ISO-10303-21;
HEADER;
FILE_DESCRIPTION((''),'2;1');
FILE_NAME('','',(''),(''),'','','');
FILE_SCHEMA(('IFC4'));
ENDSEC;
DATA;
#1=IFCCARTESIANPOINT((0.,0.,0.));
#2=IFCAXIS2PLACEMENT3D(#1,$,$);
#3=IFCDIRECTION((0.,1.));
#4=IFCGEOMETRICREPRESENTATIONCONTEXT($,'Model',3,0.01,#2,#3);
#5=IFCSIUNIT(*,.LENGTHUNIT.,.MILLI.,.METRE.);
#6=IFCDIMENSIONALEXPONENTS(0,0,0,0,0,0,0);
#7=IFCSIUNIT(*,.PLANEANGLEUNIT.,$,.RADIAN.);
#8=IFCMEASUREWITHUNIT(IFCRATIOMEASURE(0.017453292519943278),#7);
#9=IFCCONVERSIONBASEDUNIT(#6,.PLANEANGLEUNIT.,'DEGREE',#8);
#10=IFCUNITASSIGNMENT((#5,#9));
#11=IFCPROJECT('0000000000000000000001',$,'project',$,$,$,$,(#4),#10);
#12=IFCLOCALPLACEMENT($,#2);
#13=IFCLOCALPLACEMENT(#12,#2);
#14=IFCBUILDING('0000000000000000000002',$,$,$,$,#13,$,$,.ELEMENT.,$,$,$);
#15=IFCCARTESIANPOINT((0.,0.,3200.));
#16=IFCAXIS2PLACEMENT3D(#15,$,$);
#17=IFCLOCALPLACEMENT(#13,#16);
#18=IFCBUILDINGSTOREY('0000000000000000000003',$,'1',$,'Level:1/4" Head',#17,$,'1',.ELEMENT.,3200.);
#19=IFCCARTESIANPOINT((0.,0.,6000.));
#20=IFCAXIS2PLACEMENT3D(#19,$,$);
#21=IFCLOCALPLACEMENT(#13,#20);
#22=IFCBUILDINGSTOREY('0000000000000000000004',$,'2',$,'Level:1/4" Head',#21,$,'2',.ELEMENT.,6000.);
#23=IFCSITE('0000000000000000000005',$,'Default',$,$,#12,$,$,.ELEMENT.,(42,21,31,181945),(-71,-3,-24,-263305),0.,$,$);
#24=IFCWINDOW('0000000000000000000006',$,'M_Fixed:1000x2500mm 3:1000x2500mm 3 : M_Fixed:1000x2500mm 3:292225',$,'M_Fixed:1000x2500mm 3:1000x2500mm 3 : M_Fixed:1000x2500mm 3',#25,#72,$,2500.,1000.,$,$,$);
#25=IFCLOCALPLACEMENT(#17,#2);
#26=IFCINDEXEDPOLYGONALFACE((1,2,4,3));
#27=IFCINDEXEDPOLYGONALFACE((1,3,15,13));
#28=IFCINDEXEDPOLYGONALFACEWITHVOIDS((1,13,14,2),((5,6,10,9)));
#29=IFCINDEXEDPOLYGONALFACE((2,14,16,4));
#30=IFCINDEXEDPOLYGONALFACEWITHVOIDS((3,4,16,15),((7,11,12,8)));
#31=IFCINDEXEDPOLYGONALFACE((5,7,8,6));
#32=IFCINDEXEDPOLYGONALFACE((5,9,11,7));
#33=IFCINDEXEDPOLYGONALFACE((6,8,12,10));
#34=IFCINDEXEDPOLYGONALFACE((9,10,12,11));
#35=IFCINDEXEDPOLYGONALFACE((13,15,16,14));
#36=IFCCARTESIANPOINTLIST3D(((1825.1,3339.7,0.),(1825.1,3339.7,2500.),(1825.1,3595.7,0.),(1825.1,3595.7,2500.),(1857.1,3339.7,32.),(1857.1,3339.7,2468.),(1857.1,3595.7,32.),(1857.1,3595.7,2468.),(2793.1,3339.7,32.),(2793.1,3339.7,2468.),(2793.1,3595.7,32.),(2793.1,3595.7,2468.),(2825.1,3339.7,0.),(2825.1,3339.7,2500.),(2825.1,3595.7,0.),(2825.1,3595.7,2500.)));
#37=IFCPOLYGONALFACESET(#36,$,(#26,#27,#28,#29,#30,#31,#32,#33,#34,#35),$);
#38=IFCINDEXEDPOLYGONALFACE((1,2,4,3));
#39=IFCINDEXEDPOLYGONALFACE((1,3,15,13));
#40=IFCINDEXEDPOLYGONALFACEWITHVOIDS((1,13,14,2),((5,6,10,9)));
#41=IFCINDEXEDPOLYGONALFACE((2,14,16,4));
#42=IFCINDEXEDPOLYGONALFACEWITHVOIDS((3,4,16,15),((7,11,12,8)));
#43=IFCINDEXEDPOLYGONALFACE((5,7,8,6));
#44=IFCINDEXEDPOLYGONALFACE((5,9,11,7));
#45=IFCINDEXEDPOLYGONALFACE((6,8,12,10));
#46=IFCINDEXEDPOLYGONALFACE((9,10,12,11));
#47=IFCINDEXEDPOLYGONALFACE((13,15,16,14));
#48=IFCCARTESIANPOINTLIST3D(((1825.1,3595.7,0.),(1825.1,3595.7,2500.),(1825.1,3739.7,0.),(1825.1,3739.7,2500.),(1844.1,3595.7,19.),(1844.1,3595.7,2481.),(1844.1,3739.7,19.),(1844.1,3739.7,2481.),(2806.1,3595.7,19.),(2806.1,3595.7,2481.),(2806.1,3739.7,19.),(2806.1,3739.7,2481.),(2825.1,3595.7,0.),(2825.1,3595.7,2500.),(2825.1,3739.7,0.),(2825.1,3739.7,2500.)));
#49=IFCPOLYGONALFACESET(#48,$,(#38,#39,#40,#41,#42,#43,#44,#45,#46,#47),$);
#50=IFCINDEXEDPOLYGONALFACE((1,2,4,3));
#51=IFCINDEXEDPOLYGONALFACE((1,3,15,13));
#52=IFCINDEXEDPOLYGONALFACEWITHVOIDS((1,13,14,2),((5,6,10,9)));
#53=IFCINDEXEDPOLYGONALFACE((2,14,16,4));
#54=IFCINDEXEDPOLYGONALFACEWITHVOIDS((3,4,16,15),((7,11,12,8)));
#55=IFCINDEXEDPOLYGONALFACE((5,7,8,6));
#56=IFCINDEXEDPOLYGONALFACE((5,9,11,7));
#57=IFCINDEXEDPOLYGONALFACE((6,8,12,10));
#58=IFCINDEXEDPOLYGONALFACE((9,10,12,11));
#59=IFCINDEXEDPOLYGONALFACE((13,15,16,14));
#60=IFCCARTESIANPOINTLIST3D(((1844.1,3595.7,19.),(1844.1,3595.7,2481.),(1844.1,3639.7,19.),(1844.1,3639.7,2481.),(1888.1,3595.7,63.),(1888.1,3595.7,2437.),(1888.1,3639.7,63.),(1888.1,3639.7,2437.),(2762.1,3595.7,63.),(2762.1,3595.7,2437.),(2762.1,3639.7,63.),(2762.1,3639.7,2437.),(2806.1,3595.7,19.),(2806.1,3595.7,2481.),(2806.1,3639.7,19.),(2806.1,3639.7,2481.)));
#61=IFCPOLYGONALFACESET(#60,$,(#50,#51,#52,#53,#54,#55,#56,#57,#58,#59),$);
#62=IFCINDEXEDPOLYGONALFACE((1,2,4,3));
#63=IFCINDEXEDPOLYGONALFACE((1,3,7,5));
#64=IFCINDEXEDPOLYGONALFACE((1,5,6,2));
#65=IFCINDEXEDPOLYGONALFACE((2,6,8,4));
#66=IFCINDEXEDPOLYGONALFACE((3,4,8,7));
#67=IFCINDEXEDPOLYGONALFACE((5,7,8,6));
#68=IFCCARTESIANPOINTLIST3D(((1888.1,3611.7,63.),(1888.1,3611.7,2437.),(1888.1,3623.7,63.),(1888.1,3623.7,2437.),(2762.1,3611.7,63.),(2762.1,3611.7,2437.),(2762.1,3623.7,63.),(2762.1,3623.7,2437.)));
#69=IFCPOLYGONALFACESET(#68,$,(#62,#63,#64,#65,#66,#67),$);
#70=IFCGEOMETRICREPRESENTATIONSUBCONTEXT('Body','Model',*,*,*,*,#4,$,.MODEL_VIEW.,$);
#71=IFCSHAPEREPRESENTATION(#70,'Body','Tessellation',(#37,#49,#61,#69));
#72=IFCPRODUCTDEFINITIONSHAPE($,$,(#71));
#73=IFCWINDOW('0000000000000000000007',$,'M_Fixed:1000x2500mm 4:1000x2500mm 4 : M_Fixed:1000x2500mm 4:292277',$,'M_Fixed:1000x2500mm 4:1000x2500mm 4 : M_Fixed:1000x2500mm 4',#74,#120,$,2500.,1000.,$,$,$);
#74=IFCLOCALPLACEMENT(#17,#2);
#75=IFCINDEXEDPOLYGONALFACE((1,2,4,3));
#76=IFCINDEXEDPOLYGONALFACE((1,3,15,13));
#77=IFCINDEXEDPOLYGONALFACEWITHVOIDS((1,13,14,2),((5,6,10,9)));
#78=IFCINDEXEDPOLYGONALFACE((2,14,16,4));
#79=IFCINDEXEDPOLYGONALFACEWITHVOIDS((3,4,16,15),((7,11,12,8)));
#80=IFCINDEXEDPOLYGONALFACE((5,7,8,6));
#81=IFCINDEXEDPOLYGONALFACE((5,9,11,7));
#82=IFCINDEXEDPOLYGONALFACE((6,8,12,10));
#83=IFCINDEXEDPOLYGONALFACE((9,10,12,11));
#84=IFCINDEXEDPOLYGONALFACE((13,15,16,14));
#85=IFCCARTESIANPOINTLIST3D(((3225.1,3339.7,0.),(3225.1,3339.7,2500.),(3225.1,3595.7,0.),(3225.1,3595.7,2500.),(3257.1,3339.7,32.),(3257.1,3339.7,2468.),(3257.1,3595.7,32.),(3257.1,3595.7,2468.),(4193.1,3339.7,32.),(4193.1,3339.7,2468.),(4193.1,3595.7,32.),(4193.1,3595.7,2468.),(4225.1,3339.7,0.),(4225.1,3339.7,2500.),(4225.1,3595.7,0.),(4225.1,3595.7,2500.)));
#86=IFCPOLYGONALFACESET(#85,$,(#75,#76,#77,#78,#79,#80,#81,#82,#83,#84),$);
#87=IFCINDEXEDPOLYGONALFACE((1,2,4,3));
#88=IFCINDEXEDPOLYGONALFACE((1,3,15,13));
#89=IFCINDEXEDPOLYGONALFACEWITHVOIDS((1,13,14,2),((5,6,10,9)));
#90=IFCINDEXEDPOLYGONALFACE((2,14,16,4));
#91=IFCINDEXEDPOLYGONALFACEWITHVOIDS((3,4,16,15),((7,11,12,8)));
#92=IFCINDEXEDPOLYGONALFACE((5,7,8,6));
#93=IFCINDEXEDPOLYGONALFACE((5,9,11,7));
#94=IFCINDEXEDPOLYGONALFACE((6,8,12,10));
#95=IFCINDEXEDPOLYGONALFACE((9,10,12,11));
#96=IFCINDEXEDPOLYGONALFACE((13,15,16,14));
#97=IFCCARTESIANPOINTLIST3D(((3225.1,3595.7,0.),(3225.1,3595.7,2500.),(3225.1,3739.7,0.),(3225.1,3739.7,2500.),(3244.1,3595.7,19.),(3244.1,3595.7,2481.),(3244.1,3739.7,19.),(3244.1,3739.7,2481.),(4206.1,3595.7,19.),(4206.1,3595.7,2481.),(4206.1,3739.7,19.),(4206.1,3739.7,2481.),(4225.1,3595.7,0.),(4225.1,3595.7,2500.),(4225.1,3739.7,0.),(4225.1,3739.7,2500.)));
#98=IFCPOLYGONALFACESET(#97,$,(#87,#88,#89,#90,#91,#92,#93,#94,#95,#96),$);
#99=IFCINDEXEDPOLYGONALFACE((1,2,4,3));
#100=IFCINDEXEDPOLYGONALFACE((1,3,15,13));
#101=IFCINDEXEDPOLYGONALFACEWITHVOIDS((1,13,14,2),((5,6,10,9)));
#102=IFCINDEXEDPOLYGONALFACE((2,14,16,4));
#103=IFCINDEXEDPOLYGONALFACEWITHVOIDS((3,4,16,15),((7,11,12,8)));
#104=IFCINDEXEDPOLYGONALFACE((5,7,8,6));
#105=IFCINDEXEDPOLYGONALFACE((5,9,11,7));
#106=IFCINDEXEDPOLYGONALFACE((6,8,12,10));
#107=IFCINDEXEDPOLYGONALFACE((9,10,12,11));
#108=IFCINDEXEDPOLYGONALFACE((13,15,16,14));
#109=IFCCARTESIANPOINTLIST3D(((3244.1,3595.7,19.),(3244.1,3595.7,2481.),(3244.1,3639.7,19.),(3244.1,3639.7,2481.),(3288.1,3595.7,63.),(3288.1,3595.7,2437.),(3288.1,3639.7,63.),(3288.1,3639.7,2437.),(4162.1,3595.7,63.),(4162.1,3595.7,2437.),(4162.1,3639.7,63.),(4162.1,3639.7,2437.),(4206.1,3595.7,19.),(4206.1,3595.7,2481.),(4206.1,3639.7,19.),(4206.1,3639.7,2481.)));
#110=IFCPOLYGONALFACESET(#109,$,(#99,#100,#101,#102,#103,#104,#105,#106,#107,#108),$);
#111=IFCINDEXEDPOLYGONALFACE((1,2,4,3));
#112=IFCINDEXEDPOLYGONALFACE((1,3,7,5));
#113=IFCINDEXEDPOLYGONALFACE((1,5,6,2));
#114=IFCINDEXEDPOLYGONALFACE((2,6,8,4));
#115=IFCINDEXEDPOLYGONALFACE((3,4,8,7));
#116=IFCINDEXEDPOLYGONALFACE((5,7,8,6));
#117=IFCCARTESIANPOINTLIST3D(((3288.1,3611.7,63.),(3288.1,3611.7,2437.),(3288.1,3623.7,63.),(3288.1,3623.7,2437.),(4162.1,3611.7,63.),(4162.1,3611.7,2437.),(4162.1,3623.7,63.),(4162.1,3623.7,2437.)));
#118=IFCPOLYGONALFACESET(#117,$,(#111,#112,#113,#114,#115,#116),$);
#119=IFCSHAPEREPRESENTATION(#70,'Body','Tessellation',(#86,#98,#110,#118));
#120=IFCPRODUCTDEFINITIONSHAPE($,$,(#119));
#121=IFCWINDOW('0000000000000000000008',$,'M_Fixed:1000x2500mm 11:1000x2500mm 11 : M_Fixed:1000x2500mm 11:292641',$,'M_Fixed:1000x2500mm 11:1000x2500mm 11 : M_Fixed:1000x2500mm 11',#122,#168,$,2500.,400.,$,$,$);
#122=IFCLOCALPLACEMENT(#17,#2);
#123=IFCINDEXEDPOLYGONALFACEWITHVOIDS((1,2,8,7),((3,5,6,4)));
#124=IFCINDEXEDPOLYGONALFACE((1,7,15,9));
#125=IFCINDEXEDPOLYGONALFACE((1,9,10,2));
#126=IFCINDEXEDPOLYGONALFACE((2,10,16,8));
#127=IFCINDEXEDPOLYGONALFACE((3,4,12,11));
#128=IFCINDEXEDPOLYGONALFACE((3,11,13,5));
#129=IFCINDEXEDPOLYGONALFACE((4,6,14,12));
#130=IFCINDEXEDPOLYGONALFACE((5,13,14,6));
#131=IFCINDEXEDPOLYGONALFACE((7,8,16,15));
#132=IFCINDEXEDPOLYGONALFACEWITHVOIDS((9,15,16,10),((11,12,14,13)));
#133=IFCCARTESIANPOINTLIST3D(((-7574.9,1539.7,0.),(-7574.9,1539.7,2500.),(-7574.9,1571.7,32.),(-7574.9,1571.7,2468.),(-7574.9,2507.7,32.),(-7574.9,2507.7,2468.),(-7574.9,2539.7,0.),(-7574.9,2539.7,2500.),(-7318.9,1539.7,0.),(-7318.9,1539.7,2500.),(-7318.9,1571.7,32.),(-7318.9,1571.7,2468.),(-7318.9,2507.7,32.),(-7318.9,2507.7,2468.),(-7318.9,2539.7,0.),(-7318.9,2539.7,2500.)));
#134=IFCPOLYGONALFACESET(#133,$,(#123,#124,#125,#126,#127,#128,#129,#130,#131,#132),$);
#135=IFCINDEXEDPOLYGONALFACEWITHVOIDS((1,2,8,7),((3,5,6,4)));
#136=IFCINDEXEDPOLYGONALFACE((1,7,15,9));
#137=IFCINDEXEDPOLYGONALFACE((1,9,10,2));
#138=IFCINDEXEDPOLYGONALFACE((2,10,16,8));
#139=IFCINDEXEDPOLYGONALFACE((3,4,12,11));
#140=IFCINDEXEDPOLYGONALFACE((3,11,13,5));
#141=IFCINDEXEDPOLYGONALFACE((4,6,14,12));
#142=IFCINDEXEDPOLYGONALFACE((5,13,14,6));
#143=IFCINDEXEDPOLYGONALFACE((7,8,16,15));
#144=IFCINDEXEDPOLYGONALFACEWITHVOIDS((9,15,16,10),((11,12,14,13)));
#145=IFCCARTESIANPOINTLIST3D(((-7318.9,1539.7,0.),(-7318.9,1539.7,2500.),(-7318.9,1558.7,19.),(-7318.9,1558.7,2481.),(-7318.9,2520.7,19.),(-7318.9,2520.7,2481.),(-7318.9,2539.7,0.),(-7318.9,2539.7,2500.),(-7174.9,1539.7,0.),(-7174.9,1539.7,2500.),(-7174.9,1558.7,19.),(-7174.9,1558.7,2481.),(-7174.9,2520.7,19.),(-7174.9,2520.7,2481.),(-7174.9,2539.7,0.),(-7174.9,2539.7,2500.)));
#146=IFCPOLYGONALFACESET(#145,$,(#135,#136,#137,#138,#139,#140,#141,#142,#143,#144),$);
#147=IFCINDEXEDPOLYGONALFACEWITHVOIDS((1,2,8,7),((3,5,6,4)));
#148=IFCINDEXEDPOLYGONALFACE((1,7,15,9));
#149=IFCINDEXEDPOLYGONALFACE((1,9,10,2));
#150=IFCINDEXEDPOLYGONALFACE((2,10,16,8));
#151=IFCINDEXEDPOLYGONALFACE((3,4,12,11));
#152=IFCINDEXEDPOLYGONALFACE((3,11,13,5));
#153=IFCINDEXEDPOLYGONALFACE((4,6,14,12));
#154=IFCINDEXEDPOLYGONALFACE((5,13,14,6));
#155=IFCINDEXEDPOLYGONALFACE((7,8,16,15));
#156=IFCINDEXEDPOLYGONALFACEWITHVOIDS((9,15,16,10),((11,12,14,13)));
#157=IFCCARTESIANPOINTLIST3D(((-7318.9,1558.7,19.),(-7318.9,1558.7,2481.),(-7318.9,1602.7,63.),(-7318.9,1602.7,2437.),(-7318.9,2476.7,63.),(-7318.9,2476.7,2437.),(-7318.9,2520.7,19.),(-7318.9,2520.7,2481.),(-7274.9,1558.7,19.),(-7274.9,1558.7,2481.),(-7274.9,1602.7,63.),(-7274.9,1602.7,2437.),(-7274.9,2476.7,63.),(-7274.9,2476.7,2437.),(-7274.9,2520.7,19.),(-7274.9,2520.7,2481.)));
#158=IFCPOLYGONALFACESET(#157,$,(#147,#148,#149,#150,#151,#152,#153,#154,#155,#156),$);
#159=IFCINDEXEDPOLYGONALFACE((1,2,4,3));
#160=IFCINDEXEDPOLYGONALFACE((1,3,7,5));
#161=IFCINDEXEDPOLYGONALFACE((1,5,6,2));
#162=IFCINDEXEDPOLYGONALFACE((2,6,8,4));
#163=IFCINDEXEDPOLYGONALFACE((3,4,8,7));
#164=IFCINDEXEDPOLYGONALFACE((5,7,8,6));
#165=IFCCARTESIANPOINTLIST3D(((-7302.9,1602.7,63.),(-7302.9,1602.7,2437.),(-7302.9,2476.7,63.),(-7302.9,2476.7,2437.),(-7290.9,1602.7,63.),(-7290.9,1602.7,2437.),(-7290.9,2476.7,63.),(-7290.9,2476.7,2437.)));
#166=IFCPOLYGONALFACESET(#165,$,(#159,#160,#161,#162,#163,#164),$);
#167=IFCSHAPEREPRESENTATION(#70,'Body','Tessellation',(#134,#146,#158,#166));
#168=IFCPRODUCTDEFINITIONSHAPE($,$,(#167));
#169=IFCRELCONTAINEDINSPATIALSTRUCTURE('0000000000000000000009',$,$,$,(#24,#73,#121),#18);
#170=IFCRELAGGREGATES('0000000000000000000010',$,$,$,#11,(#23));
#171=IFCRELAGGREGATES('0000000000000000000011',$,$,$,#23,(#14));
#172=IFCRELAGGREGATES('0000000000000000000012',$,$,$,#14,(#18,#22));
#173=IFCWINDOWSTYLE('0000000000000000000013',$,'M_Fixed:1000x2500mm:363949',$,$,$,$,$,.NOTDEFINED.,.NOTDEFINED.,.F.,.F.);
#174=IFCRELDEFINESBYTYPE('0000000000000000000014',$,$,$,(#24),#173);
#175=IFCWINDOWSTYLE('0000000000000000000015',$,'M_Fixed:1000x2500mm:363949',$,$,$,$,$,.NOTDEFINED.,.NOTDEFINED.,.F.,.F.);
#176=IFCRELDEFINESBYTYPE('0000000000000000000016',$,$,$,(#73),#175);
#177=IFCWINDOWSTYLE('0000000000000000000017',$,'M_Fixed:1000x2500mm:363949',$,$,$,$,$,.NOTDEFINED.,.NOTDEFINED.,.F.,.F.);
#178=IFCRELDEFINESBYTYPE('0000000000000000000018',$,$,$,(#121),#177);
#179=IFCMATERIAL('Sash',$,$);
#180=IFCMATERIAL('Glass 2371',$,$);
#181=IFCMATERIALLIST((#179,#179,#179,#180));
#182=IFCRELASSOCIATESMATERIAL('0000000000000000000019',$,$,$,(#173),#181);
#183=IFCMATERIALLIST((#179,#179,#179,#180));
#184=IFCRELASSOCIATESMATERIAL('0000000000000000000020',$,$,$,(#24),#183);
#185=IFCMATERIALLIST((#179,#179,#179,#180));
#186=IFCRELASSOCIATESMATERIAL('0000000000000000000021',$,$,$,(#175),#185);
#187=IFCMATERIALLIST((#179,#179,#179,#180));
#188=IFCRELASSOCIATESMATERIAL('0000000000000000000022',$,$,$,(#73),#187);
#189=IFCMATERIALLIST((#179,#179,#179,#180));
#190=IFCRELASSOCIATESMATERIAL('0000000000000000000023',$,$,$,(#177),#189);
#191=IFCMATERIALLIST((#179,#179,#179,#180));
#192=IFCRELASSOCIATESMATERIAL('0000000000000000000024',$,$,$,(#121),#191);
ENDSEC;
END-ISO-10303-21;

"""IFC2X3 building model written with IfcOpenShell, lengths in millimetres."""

from ifc_helpers import new_model, entity, si_unit, converted_unit, direction, frame, frame_2d, origin, origin_2d_with_axis, place, context, subcontext, project, spatial, polyline, rectangle, outline, extrude, source, transform, mapped, material, material_list, type_object, type_shapes, element, save


model = new_model("IFC2X3")

# Units and contexts
model_context = context("Model", 3, precision=0.01, world=origin(), true_north=direction((0.0, 1.0)))
body_context = subcontext(model_context, "Body", "Model", "MODEL_VIEW")
ifc_project = project(units=[si_unit("LENGTHUNIT", "METRE", prefix="MILLI"), converted_unit("PLANEANGLEUNIT", "DEGREE", entity("IfcRatioMeasure", 0.017453292519943278), si_unit("PLANEANGLEUNIT", "RADIAN"), dimensions=[0, 0, 0, 0, 0, 0, 0])], contexts=[model_context])

# Site, building, storey
site_placement = place(None, origin())
site = spatial("IfcSite", under=ifc_project, at=site_placement, Name="Default", CompositionType="ELEMENT", RefLatitude=(42, 21, 31, 181945), RefLongitude=(-71, -3, -24, -263305), RefElevation=0.0)
building_placement = place(site_placement, origin())
building = spatial("IfcBuilding", under=site, at=building_placement, CompositionType="ELEMENT")
storey_1_placement = place(building_placement, frame((0.0, 0.0, 3200.0)))
storey_1 = spatial("IfcBuildingStorey", under=building, at=storey_1_placement, Name="1", ObjectType="Level:1/4\" Head", LongName="1", CompositionType="ELEMENT", Elevation=3200.0)

# Shared definitions
storey_2_placement = place(building_placement, frame((0.0, 0.0, 6000.0)))
storey_2 = spatial("IfcBuildingStorey", under=building, at=storey_2_placement, Name="2", ObjectType="Level:1/4\" Head", LongName="2", CompositionType="ELEMENT", Elevation=6000.0)

# Shared definitions
ifc_material_1 = material(Name="Sash")
ifc_material_2 = material(Name="Glass 2371")

# Windows
ifc_material_list_1 = material_list([ifc_material_1, ifc_material_1, ifc_material_1, ifc_material_2])
ifc_material_list_2 = material_list([ifc_material_1, ifc_material_1, ifc_material_1, ifc_material_2])
window_style_1 = type_object("IfcWindowStyle", Name="M_Fixed:1000x2500mm:363949", ConstructionType="NOTDEFINED", OperationType="NOTDEFINED", ParameterTakesPrecedence=False, Sizeable=False, material=ifc_material_list_2)
shared_shape_1 = source(origin(), body_context, "Body", "SweptSolid", [
    extrude(outline(polyline([(-500.0, -1250.0), (500.0, -1250.0), (500.0, 1250.0), (-500.0, 1250.0), (-500.0, -1250.0)]), holes=[polyline([(468.0, 1218.0), (468.0, -1218.0), (-468.0, -1218.0), (-468.0, 1218.0), (468.0, 1218.0)])]), frame((2325.1, 3339.7, 4450.0), z_axis=(0.0, 1.0, 0.0), x_axis=(1.0, 0.0, 0.0)), (0.0, 0.0, 1.0), 256.0),
    extrude(outline(polyline([(-500.0, -1250.0), (500.0, -1250.0), (500.0, 1250.0), (-500.0, 1250.0), (-500.0, -1250.0)]), holes=[polyline([(481.0, 1231.0), (481.0, -1231.0), (-481.0, -1231.0), (-481.0, 1231.0), (481.0, 1231.0)])]), frame((2325.1, 3595.7, 4450.0), z_axis=(0.0, 1.0, 0.0), x_axis=(1.0, 0.0, 0.0)), (0.0, 0.0, 1.0), 144.0),
    extrude(outline(polyline([(-481.0, -1231.0), (481.0, -1231.0), (481.0, 1231.0), (-481.0, 1231.0), (-481.0, -1231.0)]), holes=[polyline([(437.0, 1187.0), (437.0, -1187.0), (-437.0, -1187.0), (-437.0, 1187.0), (437.0, 1187.0)])]), frame((2325.1, 3595.7, 4450.0), z_axis=(0.0, 1.0, 0.0), x_axis=(1.0, 0.0, 0.0)), (0.0, 0.0, 1.0), 44.0),
    extrude(rectangle(XDim=12.0, YDim=874.0, at=frame_2d((0.0, 0.0), x_axis=(1.0, 0.0))), frame((2325.1, 3617.7, 3263.0), z_axis=(0.0, 0.0, 1.0), x_axis=(0.0, -1.0, 0.0)), (0.0, 0.0, 1.0), 2374.0),
])
type_shapes(window_style_1, [shared_shape_1])
window_1_placement = place(storey_1_placement, frame((0.0, 0.0, -3200.0)))
element("IfcWindow", 1, at=window_1_placement, inside=storey_1, type_object=window_style_1, material=ifc_material_list_1, Name="M_Fixed:1000x2500mm 3:1000x2500mm 3 : M_Fixed:1000x2500mm 3:292225", ObjectType="M_Fixed:1000x2500mm 3:1000x2500mm 3 : M_Fixed:1000x2500mm 3", OverallHeight=2500.0, OverallWidth=1000.0, context=body_context, shape_type="MappedRepresentation", body=[
    mapped(shared_shape_1, transform((0.0, 0.0, 0.0), scale=1.0)),
])
ifc_material_list_3 = material_list([ifc_material_1, ifc_material_1, ifc_material_1, ifc_material_2])
ifc_material_list_4 = material_list([ifc_material_1, ifc_material_1, ifc_material_1, ifc_material_2])
window_style_2 = type_object("IfcWindowStyle", Name="M_Fixed:1000x2500mm:363949", ConstructionType="NOTDEFINED", OperationType="NOTDEFINED", ParameterTakesPrecedence=False, Sizeable=False, material=ifc_material_list_4)
shared_shape_2 = source(origin(), body_context, "Body", "SweptSolid", [
    extrude(outline(polyline([(-500.0, -1250.0), (500.0, -1250.0), (500.0, 1250.0), (-500.0, 1250.0), (-500.0, -1250.0)]), holes=[polyline([(468.0, 1218.0), (468.0, -1218.0), (-468.0, -1218.0), (-468.0, 1218.0), (468.0, 1218.0)])]), frame((3725.1, 3339.7, 4450.0), z_axis=(0.0, 1.0, 0.0), x_axis=(1.0, 0.0, 0.0)), (0.0, 0.0, 1.0), 256.0),
    extrude(outline(polyline([(-500.0, -1250.0), (500.0, -1250.0), (500.0, 1250.0), (-500.0, 1250.0), (-500.0, -1250.0)]), holes=[polyline([(481.0, 1231.0), (481.0, -1231.0), (-481.0, -1231.0), (-481.0, 1231.0), (481.0, 1231.0)])]), frame((3725.1, 3595.7, 4450.0), z_axis=(0.0, 1.0, 0.0), x_axis=(1.0, 0.0, 0.0)), (0.0, 0.0, 1.0), 144.0),
    extrude(outline(polyline([(-481.0, -1231.0), (481.0, -1231.0), (481.0, 1231.0), (-481.0, 1231.0), (-481.0, -1231.0)]), holes=[polyline([(437.0, 1187.0), (437.0, -1187.0), (-437.0, -1187.0), (-437.0, 1187.0), (437.0, 1187.0)])]), frame((3725.1, 3595.7, 4450.0), z_axis=(0.0, 1.0, 0.0), x_axis=(1.0, 0.0, 0.0)), (0.0, 0.0, 1.0), 44.0),
    extrude(rectangle(XDim=12.0, YDim=874.0, at=frame_2d((0.0, 0.0), x_axis=(1.0, 0.0))), frame((3725.1, 3617.7, 3263.0), z_axis=(0.0, 0.0, 1.0), x_axis=(0.0, -1.0, 0.0)), (0.0, 0.0, 1.0), 2374.0),
])
type_shapes(window_style_2, [shared_shape_2])
window_2_placement = place(storey_1_placement, frame((0.0, 0.0, -3200.0)))
element("IfcWindow", 2, at=window_2_placement, inside=storey_1, type_object=window_style_2, material=ifc_material_list_3, Name="M_Fixed:1000x2500mm 4:1000x2500mm 4 : M_Fixed:1000x2500mm 4:292277", ObjectType="M_Fixed:1000x2500mm 4:1000x2500mm 4 : M_Fixed:1000x2500mm 4", OverallHeight=2500.0, OverallWidth=1000.0, context=body_context, shape_type="MappedRepresentation", body=[
    mapped(shared_shape_2, transform((0.0, 0.0, 0.0), scale=1.0)),
])
ifc_material_list_5 = material_list([ifc_material_1, ifc_material_1, ifc_material_1, ifc_material_2])
ifc_material_list_6 = material_list([ifc_material_1, ifc_material_1, ifc_material_1, ifc_material_2])
window_style_3 = type_object("IfcWindowStyle", Name="M_Fixed:1000x2500mm:363949", ConstructionType="NOTDEFINED", OperationType="NOTDEFINED", ParameterTakesPrecedence=False, Sizeable=False, material=ifc_material_list_6)
shared_shape_3 = source(origin(), body_context, "Body", "SweptSolid", [
    extrude(outline(polyline([(-500.0, -1250.0), (500.0, -1250.0), (500.0, 1250.0), (-500.0, 1250.0), (-500.0, -1250.0)]), holes=[polyline([(468.0, 1218.0), (468.0, -1218.0), (-468.0, -1218.0), (-468.0, 1218.0), (468.0, 1218.0)])]), frame((-7574.9, 2039.7, 4450.0), z_axis=(1.0, 0.0, 0.0), x_axis=(0.0, -1.0, 0.0)), (0.0, 0.0, 1.0), 256.0),
    extrude(outline(polyline([(-500.0, -1250.0), (500.0, -1250.0), (500.0, 1250.0), (-500.0, 1250.0), (-500.0, -1250.0)]), holes=[polyline([(481.0, 1231.0), (481.0, -1231.0), (-481.0, -1231.0), (-481.0, 1231.0), (481.0, 1231.0)])]), frame((-7318.9, 2039.7, 4450.0), z_axis=(1.0, 0.0, 0.0), x_axis=(0.0, -1.0, 0.0)), (0.0, 0.0, 1.0), 144.0),
    extrude(outline(polyline([(-481.0, -1231.0), (481.0, -1231.0), (481.0, 1231.0), (-481.0, 1231.0), (-481.0, -1231.0)]), holes=[polyline([(437.0, 1187.0), (437.0, -1187.0), (-437.0, -1187.0), (-437.0, 1187.0), (437.0, 1187.0)])]), frame((-7318.9, 2039.7, 4450.0), z_axis=(1.0, 0.0, 0.0), x_axis=(0.0, -1.0, 0.0)), (0.0, 0.0, 1.0), 44.0),
    extrude(rectangle(XDim=12.0, YDim=874.0, at=origin_2d_with_axis()), frame((-7296.9, 2039.7, 3263.0), z_axis=(0.0, 0.0, 1.0), x_axis=(-1.0, 0.0, 0.0)), (0.0, 0.0, 1.0), 2374.0),
])
type_shapes(window_style_3, [shared_shape_3])
window_3_placement = place(storey_1_placement, frame((0.0, 0.0, -3200.0)))
element("IfcWindow", 3, at=window_3_placement, inside=storey_1, type_object=window_style_3, material=ifc_material_list_5, Name="M_Fixed:1000x2500mm 11:1000x2500mm 11 : M_Fixed:1000x2500mm 11:292641", ObjectType="M_Fixed:1000x2500mm 11:1000x2500mm 11 : M_Fixed:1000x2500mm 11", OverallHeight=2500.0, OverallWidth=400.0, context=body_context, shape_type="MappedRepresentation", body=[
    mapped(shared_shape_3, transform((0.0, 0.0, 0.0), scale=1.0)),
])

save(model, "model.ifc")
